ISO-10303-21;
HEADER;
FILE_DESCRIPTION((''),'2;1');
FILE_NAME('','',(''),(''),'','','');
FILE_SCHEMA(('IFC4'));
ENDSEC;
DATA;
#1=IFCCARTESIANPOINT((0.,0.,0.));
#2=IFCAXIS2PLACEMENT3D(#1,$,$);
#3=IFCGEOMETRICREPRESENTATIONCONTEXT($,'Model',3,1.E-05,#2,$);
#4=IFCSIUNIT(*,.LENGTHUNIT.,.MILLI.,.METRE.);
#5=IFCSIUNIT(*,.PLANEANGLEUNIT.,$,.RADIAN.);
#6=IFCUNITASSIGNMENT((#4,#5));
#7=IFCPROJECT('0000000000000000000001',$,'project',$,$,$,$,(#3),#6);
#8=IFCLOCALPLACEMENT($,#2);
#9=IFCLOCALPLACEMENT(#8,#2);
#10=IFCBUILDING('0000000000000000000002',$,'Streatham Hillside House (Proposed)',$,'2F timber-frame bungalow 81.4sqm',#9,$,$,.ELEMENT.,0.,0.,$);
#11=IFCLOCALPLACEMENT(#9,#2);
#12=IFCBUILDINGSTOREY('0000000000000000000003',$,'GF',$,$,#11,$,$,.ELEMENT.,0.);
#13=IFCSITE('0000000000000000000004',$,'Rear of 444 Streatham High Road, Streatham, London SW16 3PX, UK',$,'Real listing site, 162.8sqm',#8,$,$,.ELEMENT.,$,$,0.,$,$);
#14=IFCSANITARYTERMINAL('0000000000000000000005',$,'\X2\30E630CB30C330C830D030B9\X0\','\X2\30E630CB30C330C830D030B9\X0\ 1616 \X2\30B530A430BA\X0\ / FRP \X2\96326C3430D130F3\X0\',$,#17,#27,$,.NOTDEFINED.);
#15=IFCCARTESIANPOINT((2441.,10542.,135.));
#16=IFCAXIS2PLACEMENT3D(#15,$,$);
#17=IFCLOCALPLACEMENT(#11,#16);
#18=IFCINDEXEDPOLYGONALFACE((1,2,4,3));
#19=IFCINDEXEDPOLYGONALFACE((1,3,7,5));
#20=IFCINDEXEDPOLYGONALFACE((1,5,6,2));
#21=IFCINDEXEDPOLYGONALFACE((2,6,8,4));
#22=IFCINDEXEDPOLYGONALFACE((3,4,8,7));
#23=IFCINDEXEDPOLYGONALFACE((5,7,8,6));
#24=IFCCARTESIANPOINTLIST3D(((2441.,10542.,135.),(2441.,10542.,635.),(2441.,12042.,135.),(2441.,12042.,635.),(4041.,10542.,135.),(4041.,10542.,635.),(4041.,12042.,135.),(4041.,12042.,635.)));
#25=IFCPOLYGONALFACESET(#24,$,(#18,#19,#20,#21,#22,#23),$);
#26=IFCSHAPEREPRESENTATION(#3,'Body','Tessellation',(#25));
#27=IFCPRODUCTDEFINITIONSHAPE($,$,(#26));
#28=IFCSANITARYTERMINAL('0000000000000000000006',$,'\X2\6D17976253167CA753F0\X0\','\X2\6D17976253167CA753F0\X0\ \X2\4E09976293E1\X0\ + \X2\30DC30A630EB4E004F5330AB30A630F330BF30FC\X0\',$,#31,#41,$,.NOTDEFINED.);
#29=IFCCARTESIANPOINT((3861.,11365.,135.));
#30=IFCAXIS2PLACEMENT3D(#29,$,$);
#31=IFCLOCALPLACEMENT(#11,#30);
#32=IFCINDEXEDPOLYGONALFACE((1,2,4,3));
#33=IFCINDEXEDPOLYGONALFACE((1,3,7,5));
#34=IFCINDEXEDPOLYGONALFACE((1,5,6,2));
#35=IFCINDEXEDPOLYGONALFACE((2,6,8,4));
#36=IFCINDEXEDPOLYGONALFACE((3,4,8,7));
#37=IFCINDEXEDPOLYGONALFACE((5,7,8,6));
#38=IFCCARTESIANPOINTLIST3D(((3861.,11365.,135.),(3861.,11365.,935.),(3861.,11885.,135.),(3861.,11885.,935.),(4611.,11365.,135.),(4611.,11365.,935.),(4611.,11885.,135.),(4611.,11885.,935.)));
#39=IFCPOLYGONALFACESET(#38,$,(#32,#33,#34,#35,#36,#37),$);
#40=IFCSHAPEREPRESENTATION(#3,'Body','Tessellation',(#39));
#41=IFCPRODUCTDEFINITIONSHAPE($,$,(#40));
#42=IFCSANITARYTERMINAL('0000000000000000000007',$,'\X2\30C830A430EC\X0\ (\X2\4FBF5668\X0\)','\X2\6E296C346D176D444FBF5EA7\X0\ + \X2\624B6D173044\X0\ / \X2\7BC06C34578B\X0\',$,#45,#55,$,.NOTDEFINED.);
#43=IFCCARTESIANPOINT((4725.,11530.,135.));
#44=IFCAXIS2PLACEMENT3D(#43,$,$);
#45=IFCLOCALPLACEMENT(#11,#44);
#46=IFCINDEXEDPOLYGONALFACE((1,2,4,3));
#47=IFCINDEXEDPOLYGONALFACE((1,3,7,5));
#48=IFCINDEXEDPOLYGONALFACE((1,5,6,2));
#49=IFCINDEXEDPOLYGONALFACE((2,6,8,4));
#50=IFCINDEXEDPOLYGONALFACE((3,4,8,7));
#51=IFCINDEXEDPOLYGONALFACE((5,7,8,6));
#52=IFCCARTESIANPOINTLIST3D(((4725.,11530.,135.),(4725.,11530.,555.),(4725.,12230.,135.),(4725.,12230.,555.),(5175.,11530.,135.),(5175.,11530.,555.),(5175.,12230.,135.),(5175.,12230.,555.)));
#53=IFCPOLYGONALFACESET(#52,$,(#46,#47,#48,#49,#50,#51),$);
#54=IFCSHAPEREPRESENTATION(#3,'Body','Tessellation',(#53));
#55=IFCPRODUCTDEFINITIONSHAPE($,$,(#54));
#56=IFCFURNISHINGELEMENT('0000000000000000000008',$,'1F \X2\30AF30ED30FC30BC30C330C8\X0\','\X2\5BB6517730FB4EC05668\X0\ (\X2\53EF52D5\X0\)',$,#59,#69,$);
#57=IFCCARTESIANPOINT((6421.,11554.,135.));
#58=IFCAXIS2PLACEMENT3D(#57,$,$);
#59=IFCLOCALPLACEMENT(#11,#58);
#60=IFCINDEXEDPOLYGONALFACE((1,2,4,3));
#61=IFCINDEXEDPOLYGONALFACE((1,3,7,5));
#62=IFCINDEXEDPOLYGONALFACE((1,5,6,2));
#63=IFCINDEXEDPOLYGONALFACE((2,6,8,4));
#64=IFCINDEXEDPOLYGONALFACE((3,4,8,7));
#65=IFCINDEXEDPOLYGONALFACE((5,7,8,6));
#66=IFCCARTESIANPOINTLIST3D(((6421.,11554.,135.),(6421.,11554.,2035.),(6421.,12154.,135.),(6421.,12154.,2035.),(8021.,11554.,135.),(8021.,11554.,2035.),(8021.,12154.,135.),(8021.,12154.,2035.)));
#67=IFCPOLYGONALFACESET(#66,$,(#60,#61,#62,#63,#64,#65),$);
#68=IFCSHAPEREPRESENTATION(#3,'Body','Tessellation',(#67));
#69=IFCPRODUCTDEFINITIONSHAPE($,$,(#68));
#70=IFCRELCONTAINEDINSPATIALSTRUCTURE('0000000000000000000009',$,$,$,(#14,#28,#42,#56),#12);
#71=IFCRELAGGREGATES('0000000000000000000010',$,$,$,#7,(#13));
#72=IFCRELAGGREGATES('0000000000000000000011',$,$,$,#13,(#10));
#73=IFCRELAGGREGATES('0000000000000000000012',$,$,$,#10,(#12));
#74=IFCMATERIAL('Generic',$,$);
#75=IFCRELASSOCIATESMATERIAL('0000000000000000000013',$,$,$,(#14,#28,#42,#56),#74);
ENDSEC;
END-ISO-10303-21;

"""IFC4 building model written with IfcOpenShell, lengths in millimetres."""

from ifc_helpers import new_model, si_unit, frame, frame_2d, origin, place, context, project, spatial, rectangle, extrude, material, element, save


model = new_model("IFC4")

# Units and contexts
model_context = context("Model", 3, precision=1e-05, world=origin())
ifc_project = project(units=[si_unit("LENGTHUNIT", "METRE", prefix="MILLI"), si_unit("PLANEANGLEUNIT", "RADIAN")], contexts=[model_context])

# Site, building, storey
site_placement = place(None, origin())
site = spatial("IfcSite", under=ifc_project, at=site_placement, Name="Rear of 444 Streatham High Road, Streatham, London SW16 3PX, UK", ObjectType="Real listing site, 162.8sqm", CompositionType="ELEMENT", RefElevation=0.0)
building_placement = place(site_placement, origin())
building = spatial("IfcBuilding", under=site, at=building_placement, Name="Streatham Hillside House (Proposed)", ObjectType="2F timber-frame bungalow 81.4sqm", CompositionType="ELEMENT", ElevationOfRefHeight=0.0, ElevationOfTerrain=0.0)
storey_placement = place(building_placement, origin())
storey = spatial("IfcBuildingStorey", under=building, at=storey_placement, Name="GF", CompositionType="ELEMENT", Elevation=0.0)

# Shared definitions
ifc_material_1 = material(Name="Generic")

# Sanitary terminals
sanitary_terminal_1_placement = place(storey_placement, frame((2441.0, 10542.0, 135.0)))
element("IfcSanitaryTerminal", 1, at=sanitary_terminal_1_placement, inside=storey, material=ifc_material_1, Name="ユニットバス", Description="ユニットバス 1616 サイズ / FRP 防水パン", PredefinedType="NOTDEFINED", context=model_context, shape_type="SweptSolid", body=[
    extrude(rectangle(XDim=1600.0, YDim=1500.0, at=frame_2d((800.0, 750.0))), frame((2441.0, 10542.0, 135.0)), (0.0, 0.0, 1.0), 500.0),
])
sanitary_terminal_2_placement = place(storey_placement, frame((3861.0, 11365.0, 135.0)))
element("IfcSanitaryTerminal", 2, at=sanitary_terminal_2_placement, inside=storey, material=ifc_material_1, Name="洗面化粧台", Description="洗面化粧台 三面鏡 + ボウル一体カウンター", PredefinedType="NOTDEFINED", context=model_context, shape_type="SweptSolid", body=[
    extrude(rectangle(XDim=750.0, YDim=520.0, at=frame_2d((375.0, 260.0))), frame((3861.0, 11365.0, 135.0)), (0.0, 0.0, 1.0), 800.0),
])
sanitary_terminal_3_placement = place(storey_placement, frame((4725.0, 11530.0, 135.0)))
element("IfcSanitaryTerminal", 3, at=sanitary_terminal_3_placement, inside=storey, material=ifc_material_1, Name="トイレ (便器)", Description="温水洗浄便座 + 手洗い / 節水型", PredefinedType="NOTDEFINED", context=model_context, shape_type="SweptSolid", body=[
    extrude(rectangle(XDim=450.0, YDim=700.0, at=frame_2d((225.0, 350.0))), frame((4725.0, 11530.0, 135.0)), (0.0, 0.0, 1.0), 420.0),
])

# Furnishing element
furnishing_placement = place(storey_placement, frame((6421.0, 11554.0, 135.0)))
element("IfcFurnishingElement", 4, at=furnishing_placement, inside=storey, material=ifc_material_1, Name="1F クローゼット", Description="家具・什器 (可動)", context=model_context, shape_type="SweptSolid", body=[
    extrude(rectangle(XDim=1600.0, YDim=600.0, at=frame_2d((800.0, 300.0))), frame((6421.0, 11554.0, 135.0)), (0.0, 0.0, 1.0), 1900.0),
])

save(model, "model.ifc")
